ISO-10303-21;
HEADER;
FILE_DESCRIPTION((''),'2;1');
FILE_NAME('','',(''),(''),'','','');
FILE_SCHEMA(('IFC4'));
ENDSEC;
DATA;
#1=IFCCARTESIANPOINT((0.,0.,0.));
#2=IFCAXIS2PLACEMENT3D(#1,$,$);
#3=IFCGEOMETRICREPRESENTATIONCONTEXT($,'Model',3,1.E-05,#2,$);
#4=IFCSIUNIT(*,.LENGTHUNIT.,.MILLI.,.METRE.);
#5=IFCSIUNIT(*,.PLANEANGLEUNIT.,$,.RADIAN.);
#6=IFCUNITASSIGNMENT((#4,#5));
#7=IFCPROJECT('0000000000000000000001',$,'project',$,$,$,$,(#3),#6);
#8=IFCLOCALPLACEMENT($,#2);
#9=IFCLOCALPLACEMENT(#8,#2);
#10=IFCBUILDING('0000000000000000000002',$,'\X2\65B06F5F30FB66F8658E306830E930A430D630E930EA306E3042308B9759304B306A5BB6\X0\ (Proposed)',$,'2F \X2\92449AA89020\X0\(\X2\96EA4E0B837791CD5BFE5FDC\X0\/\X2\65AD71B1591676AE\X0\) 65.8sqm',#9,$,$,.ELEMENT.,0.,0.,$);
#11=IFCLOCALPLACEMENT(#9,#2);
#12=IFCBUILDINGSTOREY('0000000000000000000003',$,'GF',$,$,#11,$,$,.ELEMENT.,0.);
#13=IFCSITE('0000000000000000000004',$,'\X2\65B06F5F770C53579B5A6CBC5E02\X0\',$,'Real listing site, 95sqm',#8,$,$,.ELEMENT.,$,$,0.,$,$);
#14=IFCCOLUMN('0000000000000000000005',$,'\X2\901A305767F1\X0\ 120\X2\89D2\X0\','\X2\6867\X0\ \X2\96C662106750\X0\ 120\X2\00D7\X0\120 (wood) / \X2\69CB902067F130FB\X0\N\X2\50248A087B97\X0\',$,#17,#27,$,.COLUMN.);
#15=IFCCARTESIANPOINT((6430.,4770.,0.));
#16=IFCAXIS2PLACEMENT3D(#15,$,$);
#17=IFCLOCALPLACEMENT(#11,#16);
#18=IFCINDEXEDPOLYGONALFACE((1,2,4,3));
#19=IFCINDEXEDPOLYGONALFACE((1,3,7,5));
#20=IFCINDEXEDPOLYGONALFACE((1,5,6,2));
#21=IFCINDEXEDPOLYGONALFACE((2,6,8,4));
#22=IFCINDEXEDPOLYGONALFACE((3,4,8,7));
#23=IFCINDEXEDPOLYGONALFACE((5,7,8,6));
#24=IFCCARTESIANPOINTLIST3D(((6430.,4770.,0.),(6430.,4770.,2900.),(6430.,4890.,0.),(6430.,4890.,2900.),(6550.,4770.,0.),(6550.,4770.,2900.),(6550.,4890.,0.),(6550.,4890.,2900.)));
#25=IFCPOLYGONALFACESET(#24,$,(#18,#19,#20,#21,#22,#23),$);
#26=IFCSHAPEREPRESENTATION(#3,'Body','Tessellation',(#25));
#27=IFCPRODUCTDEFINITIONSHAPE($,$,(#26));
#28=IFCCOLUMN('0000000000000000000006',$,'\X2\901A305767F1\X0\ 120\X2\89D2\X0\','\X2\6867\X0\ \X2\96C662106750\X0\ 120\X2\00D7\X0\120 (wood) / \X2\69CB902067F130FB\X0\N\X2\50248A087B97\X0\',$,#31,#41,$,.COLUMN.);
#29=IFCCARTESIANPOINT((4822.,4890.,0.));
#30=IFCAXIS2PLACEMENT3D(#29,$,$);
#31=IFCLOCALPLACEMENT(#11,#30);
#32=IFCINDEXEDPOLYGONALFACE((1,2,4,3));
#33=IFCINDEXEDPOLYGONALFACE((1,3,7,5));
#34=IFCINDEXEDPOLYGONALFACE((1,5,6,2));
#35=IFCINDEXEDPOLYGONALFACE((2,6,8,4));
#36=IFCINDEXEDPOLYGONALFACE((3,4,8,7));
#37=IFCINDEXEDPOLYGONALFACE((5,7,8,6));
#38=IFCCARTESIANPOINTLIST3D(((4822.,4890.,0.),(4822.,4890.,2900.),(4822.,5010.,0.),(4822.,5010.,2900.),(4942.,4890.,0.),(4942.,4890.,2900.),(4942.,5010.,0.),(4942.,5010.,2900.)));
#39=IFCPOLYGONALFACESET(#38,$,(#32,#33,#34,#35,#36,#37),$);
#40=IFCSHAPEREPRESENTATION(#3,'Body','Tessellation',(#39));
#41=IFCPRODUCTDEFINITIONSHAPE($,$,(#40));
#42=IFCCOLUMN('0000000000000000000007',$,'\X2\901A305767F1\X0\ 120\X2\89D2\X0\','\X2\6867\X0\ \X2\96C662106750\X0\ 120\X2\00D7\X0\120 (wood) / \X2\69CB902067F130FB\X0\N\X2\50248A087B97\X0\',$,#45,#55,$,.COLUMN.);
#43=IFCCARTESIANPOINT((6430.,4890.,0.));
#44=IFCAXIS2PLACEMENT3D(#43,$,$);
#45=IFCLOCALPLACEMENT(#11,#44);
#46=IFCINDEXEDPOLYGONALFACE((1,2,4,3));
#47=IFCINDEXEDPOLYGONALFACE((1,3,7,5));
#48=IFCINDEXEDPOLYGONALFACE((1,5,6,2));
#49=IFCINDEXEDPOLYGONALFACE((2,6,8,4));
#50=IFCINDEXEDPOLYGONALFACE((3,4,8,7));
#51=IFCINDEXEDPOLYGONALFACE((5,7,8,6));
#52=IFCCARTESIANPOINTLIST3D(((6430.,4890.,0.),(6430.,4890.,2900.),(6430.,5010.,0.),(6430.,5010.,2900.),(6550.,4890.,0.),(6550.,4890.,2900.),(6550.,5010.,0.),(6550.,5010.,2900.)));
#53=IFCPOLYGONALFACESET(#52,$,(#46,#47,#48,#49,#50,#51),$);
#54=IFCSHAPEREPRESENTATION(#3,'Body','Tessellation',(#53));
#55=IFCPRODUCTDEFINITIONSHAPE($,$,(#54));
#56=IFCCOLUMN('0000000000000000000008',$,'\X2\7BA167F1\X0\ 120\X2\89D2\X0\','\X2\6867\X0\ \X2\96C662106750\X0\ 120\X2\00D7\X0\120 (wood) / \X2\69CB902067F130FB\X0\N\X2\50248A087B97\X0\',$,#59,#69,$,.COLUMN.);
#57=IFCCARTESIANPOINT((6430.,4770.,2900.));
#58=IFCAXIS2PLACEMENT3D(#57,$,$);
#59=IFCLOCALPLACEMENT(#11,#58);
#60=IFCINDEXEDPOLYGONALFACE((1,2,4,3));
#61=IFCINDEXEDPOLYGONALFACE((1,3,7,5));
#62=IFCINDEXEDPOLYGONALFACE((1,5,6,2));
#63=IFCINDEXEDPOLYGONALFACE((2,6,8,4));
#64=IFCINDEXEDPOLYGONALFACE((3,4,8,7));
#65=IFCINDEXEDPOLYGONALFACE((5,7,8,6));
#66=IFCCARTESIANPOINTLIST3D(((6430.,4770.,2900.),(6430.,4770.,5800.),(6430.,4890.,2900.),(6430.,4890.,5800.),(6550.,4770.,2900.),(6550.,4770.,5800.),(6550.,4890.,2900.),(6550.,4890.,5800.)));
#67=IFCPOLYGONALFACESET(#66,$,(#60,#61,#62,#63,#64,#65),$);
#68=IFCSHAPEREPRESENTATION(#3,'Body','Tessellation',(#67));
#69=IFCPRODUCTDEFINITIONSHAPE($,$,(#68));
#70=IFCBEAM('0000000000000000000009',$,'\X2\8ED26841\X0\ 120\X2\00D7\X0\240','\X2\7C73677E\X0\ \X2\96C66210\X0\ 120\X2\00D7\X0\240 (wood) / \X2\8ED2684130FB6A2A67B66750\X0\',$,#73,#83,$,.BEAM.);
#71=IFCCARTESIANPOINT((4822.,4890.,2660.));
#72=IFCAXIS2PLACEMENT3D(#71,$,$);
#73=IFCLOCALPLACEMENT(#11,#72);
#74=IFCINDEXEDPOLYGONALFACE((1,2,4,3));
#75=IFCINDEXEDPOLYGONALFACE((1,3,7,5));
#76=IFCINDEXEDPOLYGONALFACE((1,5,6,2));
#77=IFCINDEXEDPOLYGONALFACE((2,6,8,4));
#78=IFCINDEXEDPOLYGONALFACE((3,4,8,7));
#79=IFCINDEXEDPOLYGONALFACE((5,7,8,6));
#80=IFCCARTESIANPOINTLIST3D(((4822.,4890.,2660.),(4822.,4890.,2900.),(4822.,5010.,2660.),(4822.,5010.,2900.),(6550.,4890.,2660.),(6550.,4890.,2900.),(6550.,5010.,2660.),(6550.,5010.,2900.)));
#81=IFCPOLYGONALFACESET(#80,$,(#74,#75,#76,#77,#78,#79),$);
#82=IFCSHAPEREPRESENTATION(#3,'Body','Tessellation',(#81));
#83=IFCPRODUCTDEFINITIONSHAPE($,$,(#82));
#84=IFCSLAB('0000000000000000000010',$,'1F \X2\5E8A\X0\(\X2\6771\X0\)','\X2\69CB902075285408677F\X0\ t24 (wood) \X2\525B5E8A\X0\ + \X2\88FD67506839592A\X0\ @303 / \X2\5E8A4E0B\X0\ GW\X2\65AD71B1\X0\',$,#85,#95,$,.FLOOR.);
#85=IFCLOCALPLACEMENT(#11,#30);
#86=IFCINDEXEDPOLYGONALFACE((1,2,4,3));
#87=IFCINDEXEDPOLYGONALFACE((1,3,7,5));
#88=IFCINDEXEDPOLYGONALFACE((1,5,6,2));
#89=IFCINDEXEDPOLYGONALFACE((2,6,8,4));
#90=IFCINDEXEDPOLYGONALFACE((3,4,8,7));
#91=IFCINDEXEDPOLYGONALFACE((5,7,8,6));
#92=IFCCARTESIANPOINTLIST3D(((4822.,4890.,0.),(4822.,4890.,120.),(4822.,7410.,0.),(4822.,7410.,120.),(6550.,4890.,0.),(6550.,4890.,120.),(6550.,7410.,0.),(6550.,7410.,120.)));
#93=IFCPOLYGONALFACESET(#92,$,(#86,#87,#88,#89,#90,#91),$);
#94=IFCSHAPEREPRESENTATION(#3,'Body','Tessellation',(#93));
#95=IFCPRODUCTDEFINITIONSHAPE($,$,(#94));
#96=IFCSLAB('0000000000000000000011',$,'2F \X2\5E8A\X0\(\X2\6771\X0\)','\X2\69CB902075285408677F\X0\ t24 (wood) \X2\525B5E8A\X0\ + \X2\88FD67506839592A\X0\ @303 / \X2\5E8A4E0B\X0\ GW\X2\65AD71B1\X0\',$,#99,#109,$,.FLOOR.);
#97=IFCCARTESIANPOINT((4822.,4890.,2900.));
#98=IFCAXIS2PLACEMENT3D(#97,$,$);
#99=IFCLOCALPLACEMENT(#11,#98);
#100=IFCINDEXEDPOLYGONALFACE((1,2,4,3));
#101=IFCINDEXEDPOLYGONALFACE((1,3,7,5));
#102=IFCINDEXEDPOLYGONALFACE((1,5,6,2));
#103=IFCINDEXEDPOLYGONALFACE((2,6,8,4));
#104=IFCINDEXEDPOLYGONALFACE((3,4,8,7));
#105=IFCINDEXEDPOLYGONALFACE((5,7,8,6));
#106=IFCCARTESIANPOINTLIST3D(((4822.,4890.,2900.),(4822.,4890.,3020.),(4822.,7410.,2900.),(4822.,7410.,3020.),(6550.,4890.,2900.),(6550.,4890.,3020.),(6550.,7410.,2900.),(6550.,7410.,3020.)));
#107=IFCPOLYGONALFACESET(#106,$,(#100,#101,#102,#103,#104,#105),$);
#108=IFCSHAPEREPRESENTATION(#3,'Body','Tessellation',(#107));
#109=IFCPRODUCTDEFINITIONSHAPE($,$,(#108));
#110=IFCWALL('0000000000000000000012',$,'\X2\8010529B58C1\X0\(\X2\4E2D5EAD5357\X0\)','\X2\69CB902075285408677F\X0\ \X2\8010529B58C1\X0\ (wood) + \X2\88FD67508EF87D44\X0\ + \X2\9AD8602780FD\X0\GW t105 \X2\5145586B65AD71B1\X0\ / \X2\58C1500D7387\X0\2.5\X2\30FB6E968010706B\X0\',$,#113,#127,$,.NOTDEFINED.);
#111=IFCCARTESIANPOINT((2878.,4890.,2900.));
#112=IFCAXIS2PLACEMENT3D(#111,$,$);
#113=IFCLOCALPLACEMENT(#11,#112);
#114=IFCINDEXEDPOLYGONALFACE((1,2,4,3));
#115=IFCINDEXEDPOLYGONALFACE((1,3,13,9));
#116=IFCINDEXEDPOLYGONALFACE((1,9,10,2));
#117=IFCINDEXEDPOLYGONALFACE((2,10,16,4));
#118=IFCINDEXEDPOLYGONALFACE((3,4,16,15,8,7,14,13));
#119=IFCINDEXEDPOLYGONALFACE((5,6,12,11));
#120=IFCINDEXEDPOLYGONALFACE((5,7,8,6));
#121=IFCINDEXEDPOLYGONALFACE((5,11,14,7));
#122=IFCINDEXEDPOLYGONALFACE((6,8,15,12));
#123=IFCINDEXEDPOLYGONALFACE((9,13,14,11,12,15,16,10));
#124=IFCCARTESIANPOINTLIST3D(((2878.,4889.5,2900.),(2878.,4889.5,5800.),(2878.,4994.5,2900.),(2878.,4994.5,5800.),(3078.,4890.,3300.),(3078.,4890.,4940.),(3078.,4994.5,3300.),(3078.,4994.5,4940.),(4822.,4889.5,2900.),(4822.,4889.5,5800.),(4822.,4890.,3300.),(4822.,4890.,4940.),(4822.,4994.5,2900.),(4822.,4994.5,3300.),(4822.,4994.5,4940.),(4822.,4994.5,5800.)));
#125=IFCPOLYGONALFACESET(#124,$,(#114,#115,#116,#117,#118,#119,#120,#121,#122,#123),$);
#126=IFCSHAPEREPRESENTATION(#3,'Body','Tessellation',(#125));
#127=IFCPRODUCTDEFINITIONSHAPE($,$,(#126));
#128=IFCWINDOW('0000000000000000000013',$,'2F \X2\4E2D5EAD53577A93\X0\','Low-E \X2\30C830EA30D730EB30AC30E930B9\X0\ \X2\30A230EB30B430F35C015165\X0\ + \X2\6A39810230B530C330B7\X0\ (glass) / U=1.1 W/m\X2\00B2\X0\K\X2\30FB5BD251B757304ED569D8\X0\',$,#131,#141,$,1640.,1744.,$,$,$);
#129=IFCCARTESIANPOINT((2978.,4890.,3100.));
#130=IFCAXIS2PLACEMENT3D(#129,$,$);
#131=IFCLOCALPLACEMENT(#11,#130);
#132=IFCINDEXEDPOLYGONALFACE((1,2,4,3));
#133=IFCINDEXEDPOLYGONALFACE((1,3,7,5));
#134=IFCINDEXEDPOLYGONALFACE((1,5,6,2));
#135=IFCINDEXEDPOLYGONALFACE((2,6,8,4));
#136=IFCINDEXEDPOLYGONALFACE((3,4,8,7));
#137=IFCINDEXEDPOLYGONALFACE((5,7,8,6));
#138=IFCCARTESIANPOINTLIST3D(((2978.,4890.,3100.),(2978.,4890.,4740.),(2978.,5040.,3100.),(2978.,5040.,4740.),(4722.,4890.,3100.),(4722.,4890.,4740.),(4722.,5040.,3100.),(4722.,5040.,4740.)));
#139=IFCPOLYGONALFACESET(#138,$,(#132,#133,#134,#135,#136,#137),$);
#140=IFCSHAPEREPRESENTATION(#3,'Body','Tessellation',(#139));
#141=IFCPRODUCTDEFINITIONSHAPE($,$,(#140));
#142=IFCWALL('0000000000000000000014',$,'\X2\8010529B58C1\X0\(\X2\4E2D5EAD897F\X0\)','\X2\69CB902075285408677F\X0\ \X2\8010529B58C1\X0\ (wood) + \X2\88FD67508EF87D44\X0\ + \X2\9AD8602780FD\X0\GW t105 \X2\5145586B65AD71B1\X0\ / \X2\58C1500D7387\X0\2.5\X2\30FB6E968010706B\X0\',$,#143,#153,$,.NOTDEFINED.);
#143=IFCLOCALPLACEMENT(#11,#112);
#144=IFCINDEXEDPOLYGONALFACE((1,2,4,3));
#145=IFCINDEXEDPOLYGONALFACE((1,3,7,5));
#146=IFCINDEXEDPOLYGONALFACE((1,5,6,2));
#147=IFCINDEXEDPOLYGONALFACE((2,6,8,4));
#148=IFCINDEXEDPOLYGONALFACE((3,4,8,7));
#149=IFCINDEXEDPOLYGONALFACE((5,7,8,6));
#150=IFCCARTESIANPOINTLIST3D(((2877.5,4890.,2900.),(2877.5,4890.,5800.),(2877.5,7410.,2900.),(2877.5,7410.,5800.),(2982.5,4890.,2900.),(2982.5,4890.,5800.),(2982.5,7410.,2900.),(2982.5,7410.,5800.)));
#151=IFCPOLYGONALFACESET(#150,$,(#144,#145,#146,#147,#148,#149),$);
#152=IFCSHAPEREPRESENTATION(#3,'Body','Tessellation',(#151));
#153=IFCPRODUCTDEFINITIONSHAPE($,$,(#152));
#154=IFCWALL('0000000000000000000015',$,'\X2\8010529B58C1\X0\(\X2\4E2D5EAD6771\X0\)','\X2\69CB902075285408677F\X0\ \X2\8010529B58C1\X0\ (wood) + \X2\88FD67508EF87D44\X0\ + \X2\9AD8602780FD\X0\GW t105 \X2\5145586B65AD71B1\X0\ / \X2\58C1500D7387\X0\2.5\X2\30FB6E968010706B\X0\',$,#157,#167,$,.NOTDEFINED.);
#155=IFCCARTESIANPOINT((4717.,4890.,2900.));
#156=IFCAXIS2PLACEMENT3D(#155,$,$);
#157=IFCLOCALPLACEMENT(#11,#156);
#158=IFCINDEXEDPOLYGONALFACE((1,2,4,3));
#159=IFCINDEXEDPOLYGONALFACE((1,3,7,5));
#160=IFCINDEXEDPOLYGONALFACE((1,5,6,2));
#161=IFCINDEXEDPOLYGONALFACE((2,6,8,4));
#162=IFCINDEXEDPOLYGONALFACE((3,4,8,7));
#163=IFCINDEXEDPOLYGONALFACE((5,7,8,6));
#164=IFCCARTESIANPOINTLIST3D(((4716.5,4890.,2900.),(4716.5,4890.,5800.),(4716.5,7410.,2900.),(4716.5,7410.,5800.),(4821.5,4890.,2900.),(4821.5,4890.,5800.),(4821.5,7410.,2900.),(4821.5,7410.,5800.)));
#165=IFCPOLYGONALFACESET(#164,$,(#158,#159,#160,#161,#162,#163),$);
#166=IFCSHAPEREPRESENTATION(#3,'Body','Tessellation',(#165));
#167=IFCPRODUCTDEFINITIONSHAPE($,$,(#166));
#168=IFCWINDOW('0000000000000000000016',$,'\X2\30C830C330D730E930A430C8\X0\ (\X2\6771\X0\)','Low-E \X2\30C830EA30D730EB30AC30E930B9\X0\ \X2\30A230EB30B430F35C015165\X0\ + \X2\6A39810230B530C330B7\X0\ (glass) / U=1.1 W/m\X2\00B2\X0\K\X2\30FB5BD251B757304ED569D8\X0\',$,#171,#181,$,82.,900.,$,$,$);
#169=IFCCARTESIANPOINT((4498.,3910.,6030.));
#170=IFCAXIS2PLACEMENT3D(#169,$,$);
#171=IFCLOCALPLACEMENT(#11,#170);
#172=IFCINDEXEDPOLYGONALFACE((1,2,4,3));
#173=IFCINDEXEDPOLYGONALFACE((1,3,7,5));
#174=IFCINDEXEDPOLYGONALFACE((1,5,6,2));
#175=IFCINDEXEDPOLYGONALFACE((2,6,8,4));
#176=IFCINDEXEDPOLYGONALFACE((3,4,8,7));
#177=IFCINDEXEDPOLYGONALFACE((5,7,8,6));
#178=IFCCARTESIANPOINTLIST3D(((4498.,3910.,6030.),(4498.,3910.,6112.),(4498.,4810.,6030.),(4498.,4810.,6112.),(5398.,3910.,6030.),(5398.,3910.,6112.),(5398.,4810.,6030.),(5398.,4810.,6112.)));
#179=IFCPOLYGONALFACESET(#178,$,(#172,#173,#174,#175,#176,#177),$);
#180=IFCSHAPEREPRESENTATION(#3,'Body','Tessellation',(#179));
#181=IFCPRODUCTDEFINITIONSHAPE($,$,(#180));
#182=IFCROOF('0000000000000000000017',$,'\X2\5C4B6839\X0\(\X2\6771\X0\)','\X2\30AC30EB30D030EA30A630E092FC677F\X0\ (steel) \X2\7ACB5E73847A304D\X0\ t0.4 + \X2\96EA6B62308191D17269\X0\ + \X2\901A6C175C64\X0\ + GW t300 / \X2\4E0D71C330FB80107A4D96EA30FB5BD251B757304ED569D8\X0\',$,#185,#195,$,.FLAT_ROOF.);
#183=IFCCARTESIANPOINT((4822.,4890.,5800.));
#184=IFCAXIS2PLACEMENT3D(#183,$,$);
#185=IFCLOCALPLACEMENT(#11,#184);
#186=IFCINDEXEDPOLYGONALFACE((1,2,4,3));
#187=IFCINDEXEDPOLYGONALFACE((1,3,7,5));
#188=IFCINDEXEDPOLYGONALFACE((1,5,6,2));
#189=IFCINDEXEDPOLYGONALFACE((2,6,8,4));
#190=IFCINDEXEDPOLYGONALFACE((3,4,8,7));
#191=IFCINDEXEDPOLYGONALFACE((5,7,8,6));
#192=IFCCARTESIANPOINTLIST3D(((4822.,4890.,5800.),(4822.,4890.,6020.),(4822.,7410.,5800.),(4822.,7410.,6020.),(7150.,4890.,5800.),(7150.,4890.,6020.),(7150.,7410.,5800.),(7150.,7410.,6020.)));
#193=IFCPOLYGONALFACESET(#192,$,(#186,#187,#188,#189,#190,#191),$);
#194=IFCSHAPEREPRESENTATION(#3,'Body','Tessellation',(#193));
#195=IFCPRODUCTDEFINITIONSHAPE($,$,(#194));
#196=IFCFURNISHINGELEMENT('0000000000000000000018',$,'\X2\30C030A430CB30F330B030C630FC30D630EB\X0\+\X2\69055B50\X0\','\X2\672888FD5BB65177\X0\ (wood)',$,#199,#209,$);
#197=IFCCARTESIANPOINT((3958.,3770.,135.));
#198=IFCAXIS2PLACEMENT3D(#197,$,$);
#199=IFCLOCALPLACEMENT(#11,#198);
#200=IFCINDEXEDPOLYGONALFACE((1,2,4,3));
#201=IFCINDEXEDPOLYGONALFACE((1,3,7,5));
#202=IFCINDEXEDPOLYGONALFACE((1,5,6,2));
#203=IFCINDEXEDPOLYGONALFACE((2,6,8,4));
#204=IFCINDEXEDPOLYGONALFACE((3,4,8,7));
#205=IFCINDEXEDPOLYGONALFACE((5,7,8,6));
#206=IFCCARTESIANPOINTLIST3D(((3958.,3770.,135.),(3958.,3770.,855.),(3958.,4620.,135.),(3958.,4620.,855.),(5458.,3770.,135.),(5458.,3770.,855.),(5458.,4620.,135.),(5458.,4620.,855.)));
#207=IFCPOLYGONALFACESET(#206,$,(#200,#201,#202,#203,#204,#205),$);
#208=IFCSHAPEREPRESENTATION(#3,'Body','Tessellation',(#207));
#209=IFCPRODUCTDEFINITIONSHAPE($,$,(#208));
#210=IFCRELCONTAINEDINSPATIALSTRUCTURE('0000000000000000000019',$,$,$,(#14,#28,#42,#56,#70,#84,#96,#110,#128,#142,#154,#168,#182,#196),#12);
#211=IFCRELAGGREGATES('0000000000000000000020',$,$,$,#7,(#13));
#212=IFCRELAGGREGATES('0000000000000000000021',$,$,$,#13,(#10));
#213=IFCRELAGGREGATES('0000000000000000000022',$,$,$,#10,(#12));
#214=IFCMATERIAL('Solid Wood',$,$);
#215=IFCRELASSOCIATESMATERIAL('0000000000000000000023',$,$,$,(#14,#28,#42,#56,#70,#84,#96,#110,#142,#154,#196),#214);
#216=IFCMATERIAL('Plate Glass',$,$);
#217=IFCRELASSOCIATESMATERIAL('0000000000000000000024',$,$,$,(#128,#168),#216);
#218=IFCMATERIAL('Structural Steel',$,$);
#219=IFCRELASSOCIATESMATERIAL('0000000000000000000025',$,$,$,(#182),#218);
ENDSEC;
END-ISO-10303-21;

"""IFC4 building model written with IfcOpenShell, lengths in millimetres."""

from ifc_helpers import new_model, si_unit, frame, frame_2d, origin, place, context, project, spatial, rectangle, extrude, material, element, fill, save


model = new_model("IFC4")

# Units and contexts
model_context = context("Model", 3, precision=1e-05, world=origin())
ifc_project = project(units=[si_unit("LENGTHUNIT", "METRE", prefix="MILLI"), si_unit("PLANEANGLEUNIT", "RADIAN")], contexts=[model_context])

# Site, building, storey
site_placement = place(None, origin())
site = spatial("IfcSite", under=ifc_project, at=site_placement, Name="新潟県南魚沼市", ObjectType="Real listing site, 95sqm", CompositionType="ELEMENT", RefElevation=0.0)
building_placement = place(site_placement, origin())
building = spatial("IfcBuilding", under=site, at=building_placement, Name="新潟・書斎とライブラリのある静かな家 (Proposed)", ObjectType="2F 鉄骨造(雪下荷重対応/断熱外皮) 65.8sqm", CompositionType="ELEMENT", ElevationOfRefHeight=0.0, ElevationOfTerrain=0.0)
storey_placement = place(building_placement, origin())
storey = spatial("IfcBuildingStorey", under=building, at=storey_placement, Name="GF", CompositionType="ELEMENT", Elevation=0.0)

# Columns
ifc_material_1 = material(Name="Solid Wood")
column_1_placement = place(storey_placement, frame((6430.0, 4770.0, 0.0)))
element("IfcColumn", 1, at=column_1_placement, inside=storey, material=ifc_material_1, Name="通し柱 120角", Description="桧 集成材 120×120 (wood) / 構造柱・N値計算", PredefinedType="COLUMN", context=model_context, shape_type="SweptSolid", body=[
    extrude(rectangle(XDim=120.0, YDim=120.0, at=frame_2d((60.0, 60.0))), frame((6430.0, 4770.0, 0.0)), (0.0, 0.0, 1.0), 2900.0),
])
column_2_placement = place(storey_placement, frame((4822.0, 4890.0, 0.0)))
element("IfcColumn", 2, at=column_2_placement, inside=storey, material=ifc_material_1, Name="通し柱 120角", Description="桧 集成材 120×120 (wood) / 構造柱・N値計算", PredefinedType="COLUMN", context=model_context, shape_type="SweptSolid", body=[
    extrude(rectangle(XDim=120.0, YDim=120.0, at=frame_2d((60.0, 60.0))), frame((4822.0, 4890.0, 0.0)), (0.0, 0.0, 1.0), 2900.0),
])
column_3_placement = place(storey_placement, frame((6430.0, 4890.0, 0.0)))
element("IfcColumn", 3, at=column_3_placement, inside=storey, material=ifc_material_1, Name="通し柱 120角", Description="桧 集成材 120×120 (wood) / 構造柱・N値計算", PredefinedType="COLUMN", context=model_context, shape_type="SweptSolid", body=[
    extrude(rectangle(XDim=120.0, YDim=120.0, at=frame_2d((60.0, 60.0))), frame((6430.0, 4890.0, 0.0)), (0.0, 0.0, 1.0), 2900.0),
])
column_4_placement = place(storey_placement, frame((6430.0, 4770.0, 2900.0)))
element("IfcColumn", 4, at=column_4_placement, inside=storey, material=ifc_material_1, Name="管柱 120角", Description="桧 集成材 120×120 (wood) / 構造柱・N値計算", PredefinedType="COLUMN", context=model_context, shape_type="SweptSolid", body=[
    extrude(rectangle(XDim=120.0, YDim=120.0, at=frame_2d((60.0, 60.0))), frame((6430.0, 4770.0, 2900.0)), (0.0, 0.0, 1.0), 2900.0),
])

# Beam
beam_1_placement = place(storey_placement, frame((4822.0, 4890.0, 2660.0)))
element("IfcBeam", 5, at=beam_1_placement, inside=storey, material=ifc_material_1, Name="軒桁 120×240", Description="米松 集成 120×240 (wood) / 軒桁・横架材", PredefinedType="BEAM", context=model_context, shape_type="SweptSolid", body=[
    extrude(rectangle(XDim=1728.0, YDim=120.0, at=frame_2d((864.0, 60.0))), frame((4822.0, 4890.0, 2660.0)), (0.0, 0.0, 1.0), 240.0),
])

# Slabs
slab_1_placement = place(storey_placement, frame((4822.0, 4890.0, 0.0)))
element("IfcSlab", 6, at=slab_1_placement, inside=storey, material=ifc_material_1, Name="1F 床(東)", Description="構造用合板 t24 (wood) 剛床 + 製材根太 @303 / 床下 GW断熱", PredefinedType="FLOOR", context=model_context, shape_type="SweptSolid", body=[
    extrude(rectangle(XDim=1728.0, YDim=2520.0, at=frame_2d((864.0, 1260.0))), frame((4822.0, 4890.0, 0.0)), (0.0, 0.0, 1.0), 120.0),
])
slab_2_placement = place(storey_placement, frame((4822.0, 4890.0, 2900.0)))
element("IfcSlab", 7, at=slab_2_placement, inside=storey, material=ifc_material_1, Name="2F 床(東)", Description="構造用合板 t24 (wood) 剛床 + 製材根太 @303 / 床下 GW断熱", PredefinedType="FLOOR", context=model_context, shape_type="SweptSolid", body=[
    extrude(rectangle(XDim=1728.0, YDim=2520.0, at=frame_2d((864.0, 1260.0))), frame((4822.0, 4890.0, 2900.0)), (0.0, 0.0, 1.0), 120.0),
])

# Wall, opening, window
wall_1_placement = place(storey_placement, frame((2878.0, 4890.0, 2900.0)))
wall_1 = element("IfcWall", 8, at=wall_1_placement, inside=storey, material=ifc_material_1, Name="耐力壁(中庭南)", Description="構造用合板 耐力壁 (wood) + 製材軸組 + 高性能GW t105 充填断熱 / 壁倍率2.5・準耐火", PredefinedType="NOTDEFINED", context=model_context, shape_type="SweptSolid", body=[
    extrude(rectangle(XDim=1944.0, YDim=105.0, at=frame_2d((972.0, 52.0))), frame((2878.0, 4890.0, 2900.0)), (0.0, 0.0, 1.0), 2900.0),
])
opening_placement = place(storey_placement, frame((2978.0, 4890.0, 3100.0)))
opening = element("IfcOpeningElement", 9, at=opening_placement, cuts=wall_1, PredefinedType="NOTDEFINED", context=model_context, shape_type="SweptSolid", body=[
    extrude(rectangle(XDim=1744.0, YDim=150.0, at=frame_2d((872.0, 75.0))), frame((2978.0, 4890.0, 3100.0)), (0.0, 0.0, 1.0), 1640.0),
])
ifc_material_2 = material(Name="Plate Glass")
window_1_placement = place(storey_placement, frame((2978.0, 4890.0, 3100.0)))
window_1 = element("IfcWindow", 10, at=window_1_placement, inside=storey, material=ifc_material_2, Name="2F 中庭南窓", Description="Low-E トリプルガラス アルゴン封入 + 樹脂サッシ (glass) / U=1.1 W/m²K・寒冷地仕様", OverallHeight=1640.0, OverallWidth=1744.0, context=model_context, shape_type="SweptSolid", body=[
    extrude(rectangle(XDim=1744.0, YDim=150.0, at=frame_2d((872.0, 75.0))), frame((2978.0, 4890.0, 3100.0)), (0.0, 0.0, 1.0), 1640.0),
])
fill(opening, window_1)

# Walls
wall_2_placement = place(storey_placement, frame((2878.0, 4890.0, 2900.0)))
element("IfcWall", 11, at=wall_2_placement, inside=storey, material=ifc_material_1, Name="耐力壁(中庭西)", Description="構造用合板 耐力壁 (wood) + 製材軸組 + 高性能GW t105 充填断熱 / 壁倍率2.5・準耐火", PredefinedType="NOTDEFINED", context=model_context, shape_type="SweptSolid", body=[
    extrude(rectangle(XDim=105.0, YDim=2520.0, at=frame_2d((52.0, 1260.0))), frame((2878.0, 4890.0, 2900.0)), (0.0, 0.0, 1.0), 2900.0),
])
wall_3_placement = place(storey_placement, frame((4717.0, 4890.0, 2900.0)))
element("IfcWall", 12, at=wall_3_placement, inside=storey, material=ifc_material_1, Name="耐力壁(中庭東)", Description="構造用合板 耐力壁 (wood) + 製材軸組 + 高性能GW t105 充填断熱 / 壁倍率2.5・準耐火", PredefinedType="NOTDEFINED", context=model_context, shape_type="SweptSolid", body=[
    extrude(rectangle(XDim=105.0, YDim=2520.0, at=frame_2d((52.0, 1260.0))), frame((4717.0, 4890.0, 2900.0)), (0.0, 0.0, 1.0), 2900.0),
])

# Window
window_2_placement = place(storey_placement, frame((4498.0, 3910.0, 6030.0)))
element("IfcWindow", 13, at=window_2_placement, inside=storey, material=ifc_material_2, Name="トップライト (東)", Description="Low-E トリプルガラス アルゴン封入 + 樹脂サッシ (glass) / U=1.1 W/m²K・寒冷地仕様", OverallHeight=82.0, OverallWidth=900.0, context=model_context, shape_type="SweptSolid", body=[
    extrude(rectangle(XDim=900.0, YDim=900.0, at=frame_2d((450.0, 450.0))), frame((4498.0, 3910.0, 6030.0)), (0.0, 0.0, 1.0), 82.0),
])

# Roof
ifc_material_3 = material(Name="Structural Steel")
for number, where, name in (
    (14, (4822.0, 4890.0, 5800.0), "屋根(東)"),
):
    element("IfcRoof", number, at=place(storey_placement, frame(where)), inside=storey, material=ifc_material_3, Name=name, Description="ガルバリウム鋼板 (steel) 立平葺き t0.4 + 雪止め金物 + 通気層 + GW t300 / 不燃・耐積雪・寒冷地仕様", PredefinedType="FLAT_ROOF", context=model_context, shape_type="SweptSolid", body=[
        extrude(rectangle(XDim=2328.0, YDim=2520.0, at=frame_2d((1164.0, 1260.0))), frame((4822.0, 4890.0, 5800.0)), (0.0, 0.0, 1.0), 220.0),
    ])

# Furnishing element
furnishing_1_placement = place(storey_placement, frame((3958.0, 3770.0, 135.0)))
element("IfcFurnishingElement", 15, at=furnishing_1_placement, inside=storey, material=ifc_material_1, Name="ダイニングテーブル+椅子", Description="木製家具 (wood)", context=model_context, shape_type="SweptSolid", body=[
    extrude(rectangle(XDim=1500.0, YDim=850.0, at=frame_2d((750.0, 425.0))), frame((3958.0, 3770.0, 135.0)), (0.0, 0.0, 1.0), 720.0),
])

save(model, "model.ifc")
